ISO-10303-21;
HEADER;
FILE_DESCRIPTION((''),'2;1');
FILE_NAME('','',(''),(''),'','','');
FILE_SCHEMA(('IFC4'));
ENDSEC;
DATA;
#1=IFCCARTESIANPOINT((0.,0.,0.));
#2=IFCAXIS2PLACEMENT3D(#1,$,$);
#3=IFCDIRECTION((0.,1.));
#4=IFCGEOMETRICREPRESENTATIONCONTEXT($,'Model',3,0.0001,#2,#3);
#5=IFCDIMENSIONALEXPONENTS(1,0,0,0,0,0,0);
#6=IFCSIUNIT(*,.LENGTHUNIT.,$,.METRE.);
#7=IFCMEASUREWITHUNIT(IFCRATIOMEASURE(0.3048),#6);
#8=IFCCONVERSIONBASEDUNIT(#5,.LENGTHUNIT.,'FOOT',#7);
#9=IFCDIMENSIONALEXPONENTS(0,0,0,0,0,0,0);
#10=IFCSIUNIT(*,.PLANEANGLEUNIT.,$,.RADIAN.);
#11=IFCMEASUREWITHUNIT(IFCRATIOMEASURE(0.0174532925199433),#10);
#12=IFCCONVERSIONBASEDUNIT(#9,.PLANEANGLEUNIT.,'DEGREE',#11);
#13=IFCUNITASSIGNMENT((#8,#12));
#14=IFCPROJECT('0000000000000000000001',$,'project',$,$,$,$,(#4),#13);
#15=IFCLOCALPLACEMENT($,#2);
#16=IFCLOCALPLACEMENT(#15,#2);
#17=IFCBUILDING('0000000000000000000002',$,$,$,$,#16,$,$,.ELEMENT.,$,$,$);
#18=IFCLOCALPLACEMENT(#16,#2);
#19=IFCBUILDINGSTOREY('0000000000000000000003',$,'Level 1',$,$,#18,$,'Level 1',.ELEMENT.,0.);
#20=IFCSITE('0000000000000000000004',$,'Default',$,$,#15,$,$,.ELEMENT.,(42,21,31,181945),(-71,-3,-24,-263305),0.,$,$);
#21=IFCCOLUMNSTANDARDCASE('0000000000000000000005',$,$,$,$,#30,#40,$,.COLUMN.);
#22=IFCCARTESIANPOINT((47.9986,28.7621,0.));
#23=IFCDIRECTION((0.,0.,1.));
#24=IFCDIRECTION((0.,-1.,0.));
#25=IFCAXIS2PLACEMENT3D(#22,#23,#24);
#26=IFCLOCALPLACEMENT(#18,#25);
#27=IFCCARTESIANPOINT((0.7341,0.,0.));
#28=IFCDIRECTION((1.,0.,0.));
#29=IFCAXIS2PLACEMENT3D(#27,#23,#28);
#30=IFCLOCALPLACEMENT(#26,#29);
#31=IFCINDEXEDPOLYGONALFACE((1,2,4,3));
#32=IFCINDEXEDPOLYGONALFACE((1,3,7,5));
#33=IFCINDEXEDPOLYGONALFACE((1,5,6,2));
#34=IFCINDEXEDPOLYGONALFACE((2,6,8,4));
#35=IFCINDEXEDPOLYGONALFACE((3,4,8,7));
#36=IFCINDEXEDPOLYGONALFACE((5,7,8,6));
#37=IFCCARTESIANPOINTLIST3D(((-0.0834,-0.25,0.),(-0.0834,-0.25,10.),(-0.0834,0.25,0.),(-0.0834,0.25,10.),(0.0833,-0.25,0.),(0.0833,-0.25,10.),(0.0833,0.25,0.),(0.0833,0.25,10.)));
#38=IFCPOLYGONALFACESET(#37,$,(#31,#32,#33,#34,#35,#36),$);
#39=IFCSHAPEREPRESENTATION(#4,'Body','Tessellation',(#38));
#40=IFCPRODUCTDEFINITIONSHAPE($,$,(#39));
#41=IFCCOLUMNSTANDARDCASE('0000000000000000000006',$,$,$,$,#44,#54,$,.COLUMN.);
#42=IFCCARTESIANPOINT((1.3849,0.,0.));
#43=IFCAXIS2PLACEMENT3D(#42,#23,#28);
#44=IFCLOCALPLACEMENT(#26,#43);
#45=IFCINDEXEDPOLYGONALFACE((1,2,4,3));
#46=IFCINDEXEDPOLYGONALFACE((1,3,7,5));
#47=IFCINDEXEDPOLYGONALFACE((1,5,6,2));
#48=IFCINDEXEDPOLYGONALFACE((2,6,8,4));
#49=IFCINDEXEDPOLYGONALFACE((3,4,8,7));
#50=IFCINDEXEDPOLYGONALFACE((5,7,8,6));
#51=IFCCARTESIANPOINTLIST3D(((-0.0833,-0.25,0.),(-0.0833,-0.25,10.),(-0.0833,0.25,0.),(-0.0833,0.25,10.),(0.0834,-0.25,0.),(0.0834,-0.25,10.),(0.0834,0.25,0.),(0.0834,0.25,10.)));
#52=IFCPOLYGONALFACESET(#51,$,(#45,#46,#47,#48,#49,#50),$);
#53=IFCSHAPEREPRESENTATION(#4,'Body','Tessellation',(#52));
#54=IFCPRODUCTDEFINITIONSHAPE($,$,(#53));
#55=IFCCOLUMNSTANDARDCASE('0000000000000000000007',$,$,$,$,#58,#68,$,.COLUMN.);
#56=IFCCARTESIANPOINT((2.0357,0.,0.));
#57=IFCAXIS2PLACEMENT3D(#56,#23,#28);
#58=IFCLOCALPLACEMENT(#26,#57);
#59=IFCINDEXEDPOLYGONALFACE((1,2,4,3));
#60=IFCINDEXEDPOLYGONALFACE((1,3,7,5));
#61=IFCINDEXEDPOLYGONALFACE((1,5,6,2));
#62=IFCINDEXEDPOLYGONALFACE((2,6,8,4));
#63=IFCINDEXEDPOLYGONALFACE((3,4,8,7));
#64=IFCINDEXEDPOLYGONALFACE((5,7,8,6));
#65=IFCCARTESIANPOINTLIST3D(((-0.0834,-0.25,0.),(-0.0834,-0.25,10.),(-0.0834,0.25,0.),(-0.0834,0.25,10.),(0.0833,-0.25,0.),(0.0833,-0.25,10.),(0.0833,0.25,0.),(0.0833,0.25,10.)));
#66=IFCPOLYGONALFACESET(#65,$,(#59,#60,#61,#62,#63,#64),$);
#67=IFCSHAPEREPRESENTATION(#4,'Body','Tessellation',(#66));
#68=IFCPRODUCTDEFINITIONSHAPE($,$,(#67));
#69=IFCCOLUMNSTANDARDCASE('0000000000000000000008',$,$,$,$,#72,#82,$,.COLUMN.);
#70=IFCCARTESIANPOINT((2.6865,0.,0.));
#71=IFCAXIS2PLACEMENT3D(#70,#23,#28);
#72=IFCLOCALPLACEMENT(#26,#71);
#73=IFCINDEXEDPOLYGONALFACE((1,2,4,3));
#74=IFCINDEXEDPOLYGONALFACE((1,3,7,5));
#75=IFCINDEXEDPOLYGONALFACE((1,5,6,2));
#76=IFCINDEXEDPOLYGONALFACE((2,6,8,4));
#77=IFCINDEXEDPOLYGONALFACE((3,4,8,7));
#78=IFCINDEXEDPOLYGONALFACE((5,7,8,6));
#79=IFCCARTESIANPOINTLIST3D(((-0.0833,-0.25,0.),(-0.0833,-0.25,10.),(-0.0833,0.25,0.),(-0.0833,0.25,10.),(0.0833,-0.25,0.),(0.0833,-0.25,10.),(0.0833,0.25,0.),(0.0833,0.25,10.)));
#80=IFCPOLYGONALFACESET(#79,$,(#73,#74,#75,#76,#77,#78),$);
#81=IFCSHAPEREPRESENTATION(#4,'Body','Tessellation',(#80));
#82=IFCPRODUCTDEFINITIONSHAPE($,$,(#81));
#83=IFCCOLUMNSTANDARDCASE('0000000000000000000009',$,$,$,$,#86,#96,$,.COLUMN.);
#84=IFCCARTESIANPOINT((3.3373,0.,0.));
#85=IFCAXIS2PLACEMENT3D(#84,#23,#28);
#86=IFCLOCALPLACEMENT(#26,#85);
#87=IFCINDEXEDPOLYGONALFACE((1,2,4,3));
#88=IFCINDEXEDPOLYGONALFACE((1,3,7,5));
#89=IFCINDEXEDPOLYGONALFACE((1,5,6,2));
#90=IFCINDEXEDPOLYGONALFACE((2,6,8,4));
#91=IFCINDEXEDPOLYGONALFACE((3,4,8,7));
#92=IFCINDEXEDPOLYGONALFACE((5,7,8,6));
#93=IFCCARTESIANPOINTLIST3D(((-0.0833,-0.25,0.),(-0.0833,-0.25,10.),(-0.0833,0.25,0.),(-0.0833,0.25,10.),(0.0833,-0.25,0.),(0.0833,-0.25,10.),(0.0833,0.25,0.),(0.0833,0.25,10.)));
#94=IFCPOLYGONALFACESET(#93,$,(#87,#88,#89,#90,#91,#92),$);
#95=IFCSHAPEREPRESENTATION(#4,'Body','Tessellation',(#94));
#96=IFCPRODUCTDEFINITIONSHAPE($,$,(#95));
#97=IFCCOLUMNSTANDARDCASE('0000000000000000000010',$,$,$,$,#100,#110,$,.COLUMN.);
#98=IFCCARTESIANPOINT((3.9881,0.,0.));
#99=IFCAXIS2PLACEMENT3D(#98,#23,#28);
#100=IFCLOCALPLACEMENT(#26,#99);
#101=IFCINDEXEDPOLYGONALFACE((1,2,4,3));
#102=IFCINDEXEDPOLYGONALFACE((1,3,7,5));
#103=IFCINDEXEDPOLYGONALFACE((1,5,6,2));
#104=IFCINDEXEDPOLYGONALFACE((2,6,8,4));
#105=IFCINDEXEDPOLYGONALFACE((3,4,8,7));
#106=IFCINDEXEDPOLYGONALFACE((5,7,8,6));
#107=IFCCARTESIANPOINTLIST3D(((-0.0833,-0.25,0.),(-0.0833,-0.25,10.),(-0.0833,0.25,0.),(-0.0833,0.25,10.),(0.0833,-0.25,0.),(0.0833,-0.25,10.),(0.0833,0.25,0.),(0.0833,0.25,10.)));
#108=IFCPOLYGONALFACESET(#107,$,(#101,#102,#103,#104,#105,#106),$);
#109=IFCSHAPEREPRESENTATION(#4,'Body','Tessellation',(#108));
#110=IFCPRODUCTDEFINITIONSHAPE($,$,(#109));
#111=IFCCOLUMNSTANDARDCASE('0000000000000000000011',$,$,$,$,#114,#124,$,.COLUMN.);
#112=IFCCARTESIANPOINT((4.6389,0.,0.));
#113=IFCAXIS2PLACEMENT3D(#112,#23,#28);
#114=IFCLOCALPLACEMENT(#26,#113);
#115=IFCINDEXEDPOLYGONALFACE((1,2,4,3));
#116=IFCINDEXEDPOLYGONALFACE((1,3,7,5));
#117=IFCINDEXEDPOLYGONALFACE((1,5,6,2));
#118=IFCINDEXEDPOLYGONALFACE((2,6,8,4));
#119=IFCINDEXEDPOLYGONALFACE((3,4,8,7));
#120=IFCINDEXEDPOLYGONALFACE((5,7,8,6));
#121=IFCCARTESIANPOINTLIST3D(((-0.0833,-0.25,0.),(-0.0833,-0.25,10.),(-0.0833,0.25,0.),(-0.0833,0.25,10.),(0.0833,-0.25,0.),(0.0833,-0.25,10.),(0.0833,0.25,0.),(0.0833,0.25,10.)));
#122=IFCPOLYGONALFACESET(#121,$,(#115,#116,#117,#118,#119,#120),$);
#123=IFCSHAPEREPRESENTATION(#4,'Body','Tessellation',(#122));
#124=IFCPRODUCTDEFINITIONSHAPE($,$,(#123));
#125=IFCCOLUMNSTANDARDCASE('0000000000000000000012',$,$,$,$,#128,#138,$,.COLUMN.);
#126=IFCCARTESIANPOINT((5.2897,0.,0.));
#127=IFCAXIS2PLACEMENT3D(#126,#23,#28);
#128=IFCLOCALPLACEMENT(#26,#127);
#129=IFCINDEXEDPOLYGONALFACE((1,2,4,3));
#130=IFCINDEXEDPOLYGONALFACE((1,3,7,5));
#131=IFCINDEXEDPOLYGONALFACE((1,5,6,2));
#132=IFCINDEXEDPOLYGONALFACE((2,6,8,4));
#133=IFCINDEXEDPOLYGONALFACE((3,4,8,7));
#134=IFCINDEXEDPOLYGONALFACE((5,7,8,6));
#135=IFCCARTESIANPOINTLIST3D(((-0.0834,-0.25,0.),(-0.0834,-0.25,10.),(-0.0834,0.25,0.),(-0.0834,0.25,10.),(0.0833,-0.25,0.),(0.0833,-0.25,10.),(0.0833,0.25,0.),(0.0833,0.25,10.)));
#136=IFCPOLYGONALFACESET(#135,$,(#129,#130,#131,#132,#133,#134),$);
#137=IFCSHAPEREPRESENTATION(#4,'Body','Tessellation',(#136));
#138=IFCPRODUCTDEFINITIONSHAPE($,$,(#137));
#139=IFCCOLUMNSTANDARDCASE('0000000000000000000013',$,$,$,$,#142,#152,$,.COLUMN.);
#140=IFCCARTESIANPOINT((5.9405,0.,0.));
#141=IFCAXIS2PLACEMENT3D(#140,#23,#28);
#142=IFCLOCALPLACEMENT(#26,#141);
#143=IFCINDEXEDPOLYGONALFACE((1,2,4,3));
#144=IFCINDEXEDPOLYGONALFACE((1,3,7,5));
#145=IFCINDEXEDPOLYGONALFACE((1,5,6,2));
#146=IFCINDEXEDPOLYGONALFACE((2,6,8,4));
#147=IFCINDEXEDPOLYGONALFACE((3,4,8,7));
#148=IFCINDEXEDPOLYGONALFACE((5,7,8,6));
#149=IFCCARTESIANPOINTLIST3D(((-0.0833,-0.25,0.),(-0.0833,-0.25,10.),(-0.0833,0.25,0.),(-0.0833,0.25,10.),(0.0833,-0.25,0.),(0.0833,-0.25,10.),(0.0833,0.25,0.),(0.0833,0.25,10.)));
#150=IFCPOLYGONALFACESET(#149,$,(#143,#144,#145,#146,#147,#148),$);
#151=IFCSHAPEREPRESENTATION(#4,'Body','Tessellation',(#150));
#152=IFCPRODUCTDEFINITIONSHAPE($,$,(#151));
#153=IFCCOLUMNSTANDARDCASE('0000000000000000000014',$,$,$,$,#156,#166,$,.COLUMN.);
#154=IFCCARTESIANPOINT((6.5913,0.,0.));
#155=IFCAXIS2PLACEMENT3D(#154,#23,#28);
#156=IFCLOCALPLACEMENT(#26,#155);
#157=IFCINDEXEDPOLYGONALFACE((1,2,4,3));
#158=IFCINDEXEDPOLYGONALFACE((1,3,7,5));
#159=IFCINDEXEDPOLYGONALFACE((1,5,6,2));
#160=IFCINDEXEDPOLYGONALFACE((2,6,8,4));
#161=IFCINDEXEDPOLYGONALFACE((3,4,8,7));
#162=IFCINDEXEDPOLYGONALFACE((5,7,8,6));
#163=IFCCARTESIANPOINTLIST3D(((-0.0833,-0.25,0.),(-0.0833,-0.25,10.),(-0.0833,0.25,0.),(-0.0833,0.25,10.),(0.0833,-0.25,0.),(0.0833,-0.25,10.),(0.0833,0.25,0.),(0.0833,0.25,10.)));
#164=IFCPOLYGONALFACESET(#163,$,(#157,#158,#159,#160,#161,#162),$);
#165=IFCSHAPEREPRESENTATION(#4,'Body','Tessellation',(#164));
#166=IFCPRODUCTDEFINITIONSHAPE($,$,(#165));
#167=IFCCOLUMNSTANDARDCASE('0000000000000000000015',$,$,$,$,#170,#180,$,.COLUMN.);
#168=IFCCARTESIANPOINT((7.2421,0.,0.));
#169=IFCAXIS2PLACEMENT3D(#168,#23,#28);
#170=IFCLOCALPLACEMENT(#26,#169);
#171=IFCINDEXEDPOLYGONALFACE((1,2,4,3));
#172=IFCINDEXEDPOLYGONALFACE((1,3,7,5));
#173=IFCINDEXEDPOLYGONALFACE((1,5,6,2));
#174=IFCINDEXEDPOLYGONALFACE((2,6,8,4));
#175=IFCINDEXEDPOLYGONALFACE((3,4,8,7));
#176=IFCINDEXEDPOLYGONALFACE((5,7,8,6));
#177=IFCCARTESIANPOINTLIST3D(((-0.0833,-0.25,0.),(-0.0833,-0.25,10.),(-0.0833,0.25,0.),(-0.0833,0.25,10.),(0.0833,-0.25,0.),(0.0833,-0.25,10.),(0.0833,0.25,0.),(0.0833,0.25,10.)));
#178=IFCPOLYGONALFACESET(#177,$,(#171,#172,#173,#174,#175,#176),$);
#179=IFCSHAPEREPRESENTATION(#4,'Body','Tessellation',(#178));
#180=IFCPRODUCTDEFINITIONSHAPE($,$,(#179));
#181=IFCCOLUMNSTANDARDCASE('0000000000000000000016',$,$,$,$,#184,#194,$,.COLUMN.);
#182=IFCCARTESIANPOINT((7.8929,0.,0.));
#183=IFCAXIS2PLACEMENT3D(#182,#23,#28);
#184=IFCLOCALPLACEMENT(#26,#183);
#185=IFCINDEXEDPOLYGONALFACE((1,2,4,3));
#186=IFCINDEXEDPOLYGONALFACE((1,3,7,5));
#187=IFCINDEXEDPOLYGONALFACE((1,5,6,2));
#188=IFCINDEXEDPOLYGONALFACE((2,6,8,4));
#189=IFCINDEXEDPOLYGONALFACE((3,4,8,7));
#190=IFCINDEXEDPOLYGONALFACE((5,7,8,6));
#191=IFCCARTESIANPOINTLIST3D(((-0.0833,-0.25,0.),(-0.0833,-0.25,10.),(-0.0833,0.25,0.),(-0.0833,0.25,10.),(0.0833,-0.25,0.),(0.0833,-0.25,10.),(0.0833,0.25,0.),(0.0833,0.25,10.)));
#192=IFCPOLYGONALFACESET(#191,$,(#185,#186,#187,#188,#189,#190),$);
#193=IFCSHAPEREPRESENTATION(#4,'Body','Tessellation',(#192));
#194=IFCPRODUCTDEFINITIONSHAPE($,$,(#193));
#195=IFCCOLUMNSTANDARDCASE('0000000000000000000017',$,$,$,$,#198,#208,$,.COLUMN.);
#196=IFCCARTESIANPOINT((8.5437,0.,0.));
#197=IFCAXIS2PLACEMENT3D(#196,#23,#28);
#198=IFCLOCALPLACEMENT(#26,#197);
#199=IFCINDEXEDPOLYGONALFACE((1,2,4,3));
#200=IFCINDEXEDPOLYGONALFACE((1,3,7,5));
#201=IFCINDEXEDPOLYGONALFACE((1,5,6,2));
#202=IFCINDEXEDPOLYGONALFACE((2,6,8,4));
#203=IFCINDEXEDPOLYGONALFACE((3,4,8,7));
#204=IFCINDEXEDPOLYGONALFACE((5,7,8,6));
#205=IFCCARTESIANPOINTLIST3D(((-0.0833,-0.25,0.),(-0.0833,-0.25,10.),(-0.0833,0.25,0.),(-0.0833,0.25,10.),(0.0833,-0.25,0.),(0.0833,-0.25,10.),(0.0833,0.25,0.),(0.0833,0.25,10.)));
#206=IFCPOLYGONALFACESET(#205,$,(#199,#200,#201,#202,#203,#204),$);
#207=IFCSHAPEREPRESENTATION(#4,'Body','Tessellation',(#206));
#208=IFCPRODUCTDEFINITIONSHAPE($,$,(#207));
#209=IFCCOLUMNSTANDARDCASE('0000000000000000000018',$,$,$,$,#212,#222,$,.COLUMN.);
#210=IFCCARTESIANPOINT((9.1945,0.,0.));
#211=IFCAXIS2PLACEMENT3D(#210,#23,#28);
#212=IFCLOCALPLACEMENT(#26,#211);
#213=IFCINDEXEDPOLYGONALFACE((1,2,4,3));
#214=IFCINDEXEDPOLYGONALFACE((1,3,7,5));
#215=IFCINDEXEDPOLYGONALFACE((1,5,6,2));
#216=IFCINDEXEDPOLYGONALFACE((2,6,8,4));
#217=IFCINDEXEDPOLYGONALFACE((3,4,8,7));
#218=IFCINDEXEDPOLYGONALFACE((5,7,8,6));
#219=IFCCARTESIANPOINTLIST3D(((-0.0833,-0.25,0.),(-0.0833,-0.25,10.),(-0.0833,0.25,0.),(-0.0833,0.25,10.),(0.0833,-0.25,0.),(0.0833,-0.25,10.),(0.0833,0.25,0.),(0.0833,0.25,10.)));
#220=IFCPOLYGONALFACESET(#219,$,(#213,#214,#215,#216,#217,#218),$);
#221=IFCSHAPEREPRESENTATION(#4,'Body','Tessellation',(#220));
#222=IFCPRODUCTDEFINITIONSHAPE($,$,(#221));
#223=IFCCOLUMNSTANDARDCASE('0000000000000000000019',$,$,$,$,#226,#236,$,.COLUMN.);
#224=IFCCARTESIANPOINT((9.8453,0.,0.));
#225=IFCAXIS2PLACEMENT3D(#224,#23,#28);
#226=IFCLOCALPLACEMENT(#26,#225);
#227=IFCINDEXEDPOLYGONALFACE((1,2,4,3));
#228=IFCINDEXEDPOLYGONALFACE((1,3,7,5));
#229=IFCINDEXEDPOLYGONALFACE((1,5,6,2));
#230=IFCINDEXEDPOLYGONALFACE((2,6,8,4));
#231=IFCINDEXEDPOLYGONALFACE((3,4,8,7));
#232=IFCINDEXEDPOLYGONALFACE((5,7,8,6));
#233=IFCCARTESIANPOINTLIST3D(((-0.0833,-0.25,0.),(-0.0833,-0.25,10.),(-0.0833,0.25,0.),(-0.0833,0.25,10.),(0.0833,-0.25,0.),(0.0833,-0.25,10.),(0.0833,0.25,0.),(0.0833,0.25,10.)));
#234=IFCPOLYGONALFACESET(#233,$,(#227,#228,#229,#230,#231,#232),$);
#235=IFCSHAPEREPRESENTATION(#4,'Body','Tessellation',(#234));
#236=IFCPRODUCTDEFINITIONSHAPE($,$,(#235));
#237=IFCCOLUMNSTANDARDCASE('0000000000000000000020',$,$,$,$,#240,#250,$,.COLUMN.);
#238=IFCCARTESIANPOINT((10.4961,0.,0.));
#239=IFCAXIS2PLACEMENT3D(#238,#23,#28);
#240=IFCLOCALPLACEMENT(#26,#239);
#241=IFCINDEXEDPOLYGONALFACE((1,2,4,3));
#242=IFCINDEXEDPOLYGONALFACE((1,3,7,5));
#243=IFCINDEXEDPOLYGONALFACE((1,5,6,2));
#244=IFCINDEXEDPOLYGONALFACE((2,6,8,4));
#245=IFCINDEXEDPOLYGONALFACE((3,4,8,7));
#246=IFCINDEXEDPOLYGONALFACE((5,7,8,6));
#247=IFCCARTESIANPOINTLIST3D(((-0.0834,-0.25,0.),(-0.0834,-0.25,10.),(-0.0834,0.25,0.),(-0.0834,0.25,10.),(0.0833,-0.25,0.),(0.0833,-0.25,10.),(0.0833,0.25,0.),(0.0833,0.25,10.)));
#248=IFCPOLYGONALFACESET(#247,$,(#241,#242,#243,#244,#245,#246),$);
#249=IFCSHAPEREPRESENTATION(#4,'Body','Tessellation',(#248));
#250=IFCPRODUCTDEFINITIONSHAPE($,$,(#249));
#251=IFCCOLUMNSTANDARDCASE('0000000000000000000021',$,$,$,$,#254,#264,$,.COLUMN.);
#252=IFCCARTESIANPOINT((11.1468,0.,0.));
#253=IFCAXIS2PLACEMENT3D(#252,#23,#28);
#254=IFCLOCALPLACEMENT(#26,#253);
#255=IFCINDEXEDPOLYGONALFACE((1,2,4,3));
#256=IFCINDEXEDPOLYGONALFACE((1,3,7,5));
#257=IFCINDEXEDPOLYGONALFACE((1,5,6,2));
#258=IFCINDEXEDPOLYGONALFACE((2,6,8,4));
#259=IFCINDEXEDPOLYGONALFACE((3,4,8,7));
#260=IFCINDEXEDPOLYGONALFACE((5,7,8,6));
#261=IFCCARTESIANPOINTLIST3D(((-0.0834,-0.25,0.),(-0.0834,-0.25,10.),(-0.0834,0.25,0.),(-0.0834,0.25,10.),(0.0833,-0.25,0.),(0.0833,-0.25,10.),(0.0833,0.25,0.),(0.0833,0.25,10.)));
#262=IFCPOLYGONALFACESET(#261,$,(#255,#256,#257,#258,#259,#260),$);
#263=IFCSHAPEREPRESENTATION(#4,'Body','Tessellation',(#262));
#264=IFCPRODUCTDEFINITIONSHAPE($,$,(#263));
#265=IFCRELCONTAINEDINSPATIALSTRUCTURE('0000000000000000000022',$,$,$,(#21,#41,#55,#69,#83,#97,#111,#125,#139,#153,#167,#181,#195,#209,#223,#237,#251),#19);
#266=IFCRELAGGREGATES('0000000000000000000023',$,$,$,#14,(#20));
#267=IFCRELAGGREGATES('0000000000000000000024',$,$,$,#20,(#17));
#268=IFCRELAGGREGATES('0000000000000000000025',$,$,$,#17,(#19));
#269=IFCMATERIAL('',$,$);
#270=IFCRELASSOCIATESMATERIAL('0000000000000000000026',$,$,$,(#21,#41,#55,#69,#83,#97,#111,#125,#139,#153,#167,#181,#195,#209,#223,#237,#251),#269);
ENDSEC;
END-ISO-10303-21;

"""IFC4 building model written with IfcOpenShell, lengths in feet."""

from ifc_helpers import new_model, entity, si_unit, converted_unit, direction, frame, origin, place, context, project, spatial, rectangle, extrude, material, element, save


model = new_model("IFC4")

# Units and contexts
model_context = context("Model", 3, precision=0.0001, world=origin(), true_north=direction((0.0, 1.0)))
ifc_project = project(units=[converted_unit("LENGTHUNIT", "FOOT", entity("IfcRatioMeasure", 0.3048), si_unit("LENGTHUNIT", "METRE"), dimensions=[1, 0, 0, 0, 0, 0, 0]), converted_unit("PLANEANGLEUNIT", "DEGREE", entity("IfcRatioMeasure", 0.0174532925199433), si_unit("PLANEANGLEUNIT", "RADIAN"), dimensions=[0, 0, 0, 0, 0, 0, 0])], contexts=[model_context])

# Site, building, storey
site_placement = place(None, origin())
site = spatial("IfcSite", under=ifc_project, at=site_placement, Name="Default", CompositionType="ELEMENT", RefLatitude=(42, 21, 31, 181945), RefLongitude=(-71, -3, -24, -263305), RefElevation=0.0)
building_placement = place(site_placement, origin())
building = spatial("IfcBuilding", under=site, at=building_placement, CompositionType="ELEMENT")
storey_placement = place(building_placement, origin())
storey = spatial("IfcBuildingStorey", under=building, at=storey_placement, Name="Level 1", LongName="Level 1", CompositionType="ELEMENT", Elevation=0.0)

# Columns
ifc_material_1 = material(Name="")
placement_1 = place(storey_placement, frame((47.9986, 28.7621, 0.0), z_axis=(0.0, 0.0, 1.0), x_axis=(0.0, -1.0, 0.0)))
for number, where, z_axis, x_axis in (
    (1, (0.7341, 0.0, 0.0), (0.0, 0.0, 1.0), (1.0, 0.0, 0.0)),
    (2, (1.3849, 0.0, 0.0), (0.0, 0.0, 1.0), (1.0, 0.0, 0.0)),
    (3, (2.0357, 0.0, 0.0), (0.0, 0.0, 1.0), (1.0, 0.0, 0.0)),
    (4, (2.6865, 0.0, 0.0), (0.0, 0.0, 1.0), (1.0, 0.0, 0.0)),
    (5, (3.3373, 0.0, 0.0), (0.0, 0.0, 1.0), (1.0, 0.0, 0.0)),
    (6, (3.9881, 0.0, 0.0), (0.0, 0.0, 1.0), (1.0, 0.0, 0.0)),
    (7, (4.6389, 0.0, 0.0), (0.0, 0.0, 1.0), (1.0, 0.0, 0.0)),
    (8, (5.2897, 0.0, 0.0), (0.0, 0.0, 1.0), (1.0, 0.0, 0.0)),
    (9, (5.9405, 0.0, 0.0), (0.0, 0.0, 1.0), (1.0, 0.0, 0.0)),
    (10, (6.5913, 0.0, 0.0), (0.0, 0.0, 1.0), (1.0, 0.0, 0.0)),
    (11, (7.2421, 0.0, 0.0), (0.0, 0.0, 1.0), (1.0, 0.0, 0.0)),
    (12, (7.8929, 0.0, 0.0), (0.0, 0.0, 1.0), (1.0, 0.0, 0.0)),
    (13, (8.5437, 0.0, 0.0), (0.0, 0.0, 1.0), (1.0, 0.0, 0.0)),
    (14, (9.1945, 0.0, 0.0), (0.0, 0.0, 1.0), (1.0, 0.0, 0.0)),
    (15, (9.8453, 0.0, 0.0), (0.0, 0.0, 1.0), (1.0, 0.0, 0.0)),
    (16, (10.4961, 0.0, 0.0), (0.0, 0.0, 1.0), (1.0, 0.0, 0.0)),
    (17, (11.1468, 0.0, 0.0), (0.0, 0.0, 1.0), (1.0, 0.0, 0.0)),
):
    element("IfcColumnStandardCase", number, at=place(placement_1, frame(where, z_axis=z_axis, x_axis=x_axis)), inside=storey, material=ifc_material_1, PredefinedType="COLUMN", context=model_context, shape_type="SweptSolid", body=[
        extrude(rectangle(XDim=0.1667, YDim=0.5), origin(), (0.0, 0.0, 1.0), 10.0),
    ])

save(model, "model.ifc")
